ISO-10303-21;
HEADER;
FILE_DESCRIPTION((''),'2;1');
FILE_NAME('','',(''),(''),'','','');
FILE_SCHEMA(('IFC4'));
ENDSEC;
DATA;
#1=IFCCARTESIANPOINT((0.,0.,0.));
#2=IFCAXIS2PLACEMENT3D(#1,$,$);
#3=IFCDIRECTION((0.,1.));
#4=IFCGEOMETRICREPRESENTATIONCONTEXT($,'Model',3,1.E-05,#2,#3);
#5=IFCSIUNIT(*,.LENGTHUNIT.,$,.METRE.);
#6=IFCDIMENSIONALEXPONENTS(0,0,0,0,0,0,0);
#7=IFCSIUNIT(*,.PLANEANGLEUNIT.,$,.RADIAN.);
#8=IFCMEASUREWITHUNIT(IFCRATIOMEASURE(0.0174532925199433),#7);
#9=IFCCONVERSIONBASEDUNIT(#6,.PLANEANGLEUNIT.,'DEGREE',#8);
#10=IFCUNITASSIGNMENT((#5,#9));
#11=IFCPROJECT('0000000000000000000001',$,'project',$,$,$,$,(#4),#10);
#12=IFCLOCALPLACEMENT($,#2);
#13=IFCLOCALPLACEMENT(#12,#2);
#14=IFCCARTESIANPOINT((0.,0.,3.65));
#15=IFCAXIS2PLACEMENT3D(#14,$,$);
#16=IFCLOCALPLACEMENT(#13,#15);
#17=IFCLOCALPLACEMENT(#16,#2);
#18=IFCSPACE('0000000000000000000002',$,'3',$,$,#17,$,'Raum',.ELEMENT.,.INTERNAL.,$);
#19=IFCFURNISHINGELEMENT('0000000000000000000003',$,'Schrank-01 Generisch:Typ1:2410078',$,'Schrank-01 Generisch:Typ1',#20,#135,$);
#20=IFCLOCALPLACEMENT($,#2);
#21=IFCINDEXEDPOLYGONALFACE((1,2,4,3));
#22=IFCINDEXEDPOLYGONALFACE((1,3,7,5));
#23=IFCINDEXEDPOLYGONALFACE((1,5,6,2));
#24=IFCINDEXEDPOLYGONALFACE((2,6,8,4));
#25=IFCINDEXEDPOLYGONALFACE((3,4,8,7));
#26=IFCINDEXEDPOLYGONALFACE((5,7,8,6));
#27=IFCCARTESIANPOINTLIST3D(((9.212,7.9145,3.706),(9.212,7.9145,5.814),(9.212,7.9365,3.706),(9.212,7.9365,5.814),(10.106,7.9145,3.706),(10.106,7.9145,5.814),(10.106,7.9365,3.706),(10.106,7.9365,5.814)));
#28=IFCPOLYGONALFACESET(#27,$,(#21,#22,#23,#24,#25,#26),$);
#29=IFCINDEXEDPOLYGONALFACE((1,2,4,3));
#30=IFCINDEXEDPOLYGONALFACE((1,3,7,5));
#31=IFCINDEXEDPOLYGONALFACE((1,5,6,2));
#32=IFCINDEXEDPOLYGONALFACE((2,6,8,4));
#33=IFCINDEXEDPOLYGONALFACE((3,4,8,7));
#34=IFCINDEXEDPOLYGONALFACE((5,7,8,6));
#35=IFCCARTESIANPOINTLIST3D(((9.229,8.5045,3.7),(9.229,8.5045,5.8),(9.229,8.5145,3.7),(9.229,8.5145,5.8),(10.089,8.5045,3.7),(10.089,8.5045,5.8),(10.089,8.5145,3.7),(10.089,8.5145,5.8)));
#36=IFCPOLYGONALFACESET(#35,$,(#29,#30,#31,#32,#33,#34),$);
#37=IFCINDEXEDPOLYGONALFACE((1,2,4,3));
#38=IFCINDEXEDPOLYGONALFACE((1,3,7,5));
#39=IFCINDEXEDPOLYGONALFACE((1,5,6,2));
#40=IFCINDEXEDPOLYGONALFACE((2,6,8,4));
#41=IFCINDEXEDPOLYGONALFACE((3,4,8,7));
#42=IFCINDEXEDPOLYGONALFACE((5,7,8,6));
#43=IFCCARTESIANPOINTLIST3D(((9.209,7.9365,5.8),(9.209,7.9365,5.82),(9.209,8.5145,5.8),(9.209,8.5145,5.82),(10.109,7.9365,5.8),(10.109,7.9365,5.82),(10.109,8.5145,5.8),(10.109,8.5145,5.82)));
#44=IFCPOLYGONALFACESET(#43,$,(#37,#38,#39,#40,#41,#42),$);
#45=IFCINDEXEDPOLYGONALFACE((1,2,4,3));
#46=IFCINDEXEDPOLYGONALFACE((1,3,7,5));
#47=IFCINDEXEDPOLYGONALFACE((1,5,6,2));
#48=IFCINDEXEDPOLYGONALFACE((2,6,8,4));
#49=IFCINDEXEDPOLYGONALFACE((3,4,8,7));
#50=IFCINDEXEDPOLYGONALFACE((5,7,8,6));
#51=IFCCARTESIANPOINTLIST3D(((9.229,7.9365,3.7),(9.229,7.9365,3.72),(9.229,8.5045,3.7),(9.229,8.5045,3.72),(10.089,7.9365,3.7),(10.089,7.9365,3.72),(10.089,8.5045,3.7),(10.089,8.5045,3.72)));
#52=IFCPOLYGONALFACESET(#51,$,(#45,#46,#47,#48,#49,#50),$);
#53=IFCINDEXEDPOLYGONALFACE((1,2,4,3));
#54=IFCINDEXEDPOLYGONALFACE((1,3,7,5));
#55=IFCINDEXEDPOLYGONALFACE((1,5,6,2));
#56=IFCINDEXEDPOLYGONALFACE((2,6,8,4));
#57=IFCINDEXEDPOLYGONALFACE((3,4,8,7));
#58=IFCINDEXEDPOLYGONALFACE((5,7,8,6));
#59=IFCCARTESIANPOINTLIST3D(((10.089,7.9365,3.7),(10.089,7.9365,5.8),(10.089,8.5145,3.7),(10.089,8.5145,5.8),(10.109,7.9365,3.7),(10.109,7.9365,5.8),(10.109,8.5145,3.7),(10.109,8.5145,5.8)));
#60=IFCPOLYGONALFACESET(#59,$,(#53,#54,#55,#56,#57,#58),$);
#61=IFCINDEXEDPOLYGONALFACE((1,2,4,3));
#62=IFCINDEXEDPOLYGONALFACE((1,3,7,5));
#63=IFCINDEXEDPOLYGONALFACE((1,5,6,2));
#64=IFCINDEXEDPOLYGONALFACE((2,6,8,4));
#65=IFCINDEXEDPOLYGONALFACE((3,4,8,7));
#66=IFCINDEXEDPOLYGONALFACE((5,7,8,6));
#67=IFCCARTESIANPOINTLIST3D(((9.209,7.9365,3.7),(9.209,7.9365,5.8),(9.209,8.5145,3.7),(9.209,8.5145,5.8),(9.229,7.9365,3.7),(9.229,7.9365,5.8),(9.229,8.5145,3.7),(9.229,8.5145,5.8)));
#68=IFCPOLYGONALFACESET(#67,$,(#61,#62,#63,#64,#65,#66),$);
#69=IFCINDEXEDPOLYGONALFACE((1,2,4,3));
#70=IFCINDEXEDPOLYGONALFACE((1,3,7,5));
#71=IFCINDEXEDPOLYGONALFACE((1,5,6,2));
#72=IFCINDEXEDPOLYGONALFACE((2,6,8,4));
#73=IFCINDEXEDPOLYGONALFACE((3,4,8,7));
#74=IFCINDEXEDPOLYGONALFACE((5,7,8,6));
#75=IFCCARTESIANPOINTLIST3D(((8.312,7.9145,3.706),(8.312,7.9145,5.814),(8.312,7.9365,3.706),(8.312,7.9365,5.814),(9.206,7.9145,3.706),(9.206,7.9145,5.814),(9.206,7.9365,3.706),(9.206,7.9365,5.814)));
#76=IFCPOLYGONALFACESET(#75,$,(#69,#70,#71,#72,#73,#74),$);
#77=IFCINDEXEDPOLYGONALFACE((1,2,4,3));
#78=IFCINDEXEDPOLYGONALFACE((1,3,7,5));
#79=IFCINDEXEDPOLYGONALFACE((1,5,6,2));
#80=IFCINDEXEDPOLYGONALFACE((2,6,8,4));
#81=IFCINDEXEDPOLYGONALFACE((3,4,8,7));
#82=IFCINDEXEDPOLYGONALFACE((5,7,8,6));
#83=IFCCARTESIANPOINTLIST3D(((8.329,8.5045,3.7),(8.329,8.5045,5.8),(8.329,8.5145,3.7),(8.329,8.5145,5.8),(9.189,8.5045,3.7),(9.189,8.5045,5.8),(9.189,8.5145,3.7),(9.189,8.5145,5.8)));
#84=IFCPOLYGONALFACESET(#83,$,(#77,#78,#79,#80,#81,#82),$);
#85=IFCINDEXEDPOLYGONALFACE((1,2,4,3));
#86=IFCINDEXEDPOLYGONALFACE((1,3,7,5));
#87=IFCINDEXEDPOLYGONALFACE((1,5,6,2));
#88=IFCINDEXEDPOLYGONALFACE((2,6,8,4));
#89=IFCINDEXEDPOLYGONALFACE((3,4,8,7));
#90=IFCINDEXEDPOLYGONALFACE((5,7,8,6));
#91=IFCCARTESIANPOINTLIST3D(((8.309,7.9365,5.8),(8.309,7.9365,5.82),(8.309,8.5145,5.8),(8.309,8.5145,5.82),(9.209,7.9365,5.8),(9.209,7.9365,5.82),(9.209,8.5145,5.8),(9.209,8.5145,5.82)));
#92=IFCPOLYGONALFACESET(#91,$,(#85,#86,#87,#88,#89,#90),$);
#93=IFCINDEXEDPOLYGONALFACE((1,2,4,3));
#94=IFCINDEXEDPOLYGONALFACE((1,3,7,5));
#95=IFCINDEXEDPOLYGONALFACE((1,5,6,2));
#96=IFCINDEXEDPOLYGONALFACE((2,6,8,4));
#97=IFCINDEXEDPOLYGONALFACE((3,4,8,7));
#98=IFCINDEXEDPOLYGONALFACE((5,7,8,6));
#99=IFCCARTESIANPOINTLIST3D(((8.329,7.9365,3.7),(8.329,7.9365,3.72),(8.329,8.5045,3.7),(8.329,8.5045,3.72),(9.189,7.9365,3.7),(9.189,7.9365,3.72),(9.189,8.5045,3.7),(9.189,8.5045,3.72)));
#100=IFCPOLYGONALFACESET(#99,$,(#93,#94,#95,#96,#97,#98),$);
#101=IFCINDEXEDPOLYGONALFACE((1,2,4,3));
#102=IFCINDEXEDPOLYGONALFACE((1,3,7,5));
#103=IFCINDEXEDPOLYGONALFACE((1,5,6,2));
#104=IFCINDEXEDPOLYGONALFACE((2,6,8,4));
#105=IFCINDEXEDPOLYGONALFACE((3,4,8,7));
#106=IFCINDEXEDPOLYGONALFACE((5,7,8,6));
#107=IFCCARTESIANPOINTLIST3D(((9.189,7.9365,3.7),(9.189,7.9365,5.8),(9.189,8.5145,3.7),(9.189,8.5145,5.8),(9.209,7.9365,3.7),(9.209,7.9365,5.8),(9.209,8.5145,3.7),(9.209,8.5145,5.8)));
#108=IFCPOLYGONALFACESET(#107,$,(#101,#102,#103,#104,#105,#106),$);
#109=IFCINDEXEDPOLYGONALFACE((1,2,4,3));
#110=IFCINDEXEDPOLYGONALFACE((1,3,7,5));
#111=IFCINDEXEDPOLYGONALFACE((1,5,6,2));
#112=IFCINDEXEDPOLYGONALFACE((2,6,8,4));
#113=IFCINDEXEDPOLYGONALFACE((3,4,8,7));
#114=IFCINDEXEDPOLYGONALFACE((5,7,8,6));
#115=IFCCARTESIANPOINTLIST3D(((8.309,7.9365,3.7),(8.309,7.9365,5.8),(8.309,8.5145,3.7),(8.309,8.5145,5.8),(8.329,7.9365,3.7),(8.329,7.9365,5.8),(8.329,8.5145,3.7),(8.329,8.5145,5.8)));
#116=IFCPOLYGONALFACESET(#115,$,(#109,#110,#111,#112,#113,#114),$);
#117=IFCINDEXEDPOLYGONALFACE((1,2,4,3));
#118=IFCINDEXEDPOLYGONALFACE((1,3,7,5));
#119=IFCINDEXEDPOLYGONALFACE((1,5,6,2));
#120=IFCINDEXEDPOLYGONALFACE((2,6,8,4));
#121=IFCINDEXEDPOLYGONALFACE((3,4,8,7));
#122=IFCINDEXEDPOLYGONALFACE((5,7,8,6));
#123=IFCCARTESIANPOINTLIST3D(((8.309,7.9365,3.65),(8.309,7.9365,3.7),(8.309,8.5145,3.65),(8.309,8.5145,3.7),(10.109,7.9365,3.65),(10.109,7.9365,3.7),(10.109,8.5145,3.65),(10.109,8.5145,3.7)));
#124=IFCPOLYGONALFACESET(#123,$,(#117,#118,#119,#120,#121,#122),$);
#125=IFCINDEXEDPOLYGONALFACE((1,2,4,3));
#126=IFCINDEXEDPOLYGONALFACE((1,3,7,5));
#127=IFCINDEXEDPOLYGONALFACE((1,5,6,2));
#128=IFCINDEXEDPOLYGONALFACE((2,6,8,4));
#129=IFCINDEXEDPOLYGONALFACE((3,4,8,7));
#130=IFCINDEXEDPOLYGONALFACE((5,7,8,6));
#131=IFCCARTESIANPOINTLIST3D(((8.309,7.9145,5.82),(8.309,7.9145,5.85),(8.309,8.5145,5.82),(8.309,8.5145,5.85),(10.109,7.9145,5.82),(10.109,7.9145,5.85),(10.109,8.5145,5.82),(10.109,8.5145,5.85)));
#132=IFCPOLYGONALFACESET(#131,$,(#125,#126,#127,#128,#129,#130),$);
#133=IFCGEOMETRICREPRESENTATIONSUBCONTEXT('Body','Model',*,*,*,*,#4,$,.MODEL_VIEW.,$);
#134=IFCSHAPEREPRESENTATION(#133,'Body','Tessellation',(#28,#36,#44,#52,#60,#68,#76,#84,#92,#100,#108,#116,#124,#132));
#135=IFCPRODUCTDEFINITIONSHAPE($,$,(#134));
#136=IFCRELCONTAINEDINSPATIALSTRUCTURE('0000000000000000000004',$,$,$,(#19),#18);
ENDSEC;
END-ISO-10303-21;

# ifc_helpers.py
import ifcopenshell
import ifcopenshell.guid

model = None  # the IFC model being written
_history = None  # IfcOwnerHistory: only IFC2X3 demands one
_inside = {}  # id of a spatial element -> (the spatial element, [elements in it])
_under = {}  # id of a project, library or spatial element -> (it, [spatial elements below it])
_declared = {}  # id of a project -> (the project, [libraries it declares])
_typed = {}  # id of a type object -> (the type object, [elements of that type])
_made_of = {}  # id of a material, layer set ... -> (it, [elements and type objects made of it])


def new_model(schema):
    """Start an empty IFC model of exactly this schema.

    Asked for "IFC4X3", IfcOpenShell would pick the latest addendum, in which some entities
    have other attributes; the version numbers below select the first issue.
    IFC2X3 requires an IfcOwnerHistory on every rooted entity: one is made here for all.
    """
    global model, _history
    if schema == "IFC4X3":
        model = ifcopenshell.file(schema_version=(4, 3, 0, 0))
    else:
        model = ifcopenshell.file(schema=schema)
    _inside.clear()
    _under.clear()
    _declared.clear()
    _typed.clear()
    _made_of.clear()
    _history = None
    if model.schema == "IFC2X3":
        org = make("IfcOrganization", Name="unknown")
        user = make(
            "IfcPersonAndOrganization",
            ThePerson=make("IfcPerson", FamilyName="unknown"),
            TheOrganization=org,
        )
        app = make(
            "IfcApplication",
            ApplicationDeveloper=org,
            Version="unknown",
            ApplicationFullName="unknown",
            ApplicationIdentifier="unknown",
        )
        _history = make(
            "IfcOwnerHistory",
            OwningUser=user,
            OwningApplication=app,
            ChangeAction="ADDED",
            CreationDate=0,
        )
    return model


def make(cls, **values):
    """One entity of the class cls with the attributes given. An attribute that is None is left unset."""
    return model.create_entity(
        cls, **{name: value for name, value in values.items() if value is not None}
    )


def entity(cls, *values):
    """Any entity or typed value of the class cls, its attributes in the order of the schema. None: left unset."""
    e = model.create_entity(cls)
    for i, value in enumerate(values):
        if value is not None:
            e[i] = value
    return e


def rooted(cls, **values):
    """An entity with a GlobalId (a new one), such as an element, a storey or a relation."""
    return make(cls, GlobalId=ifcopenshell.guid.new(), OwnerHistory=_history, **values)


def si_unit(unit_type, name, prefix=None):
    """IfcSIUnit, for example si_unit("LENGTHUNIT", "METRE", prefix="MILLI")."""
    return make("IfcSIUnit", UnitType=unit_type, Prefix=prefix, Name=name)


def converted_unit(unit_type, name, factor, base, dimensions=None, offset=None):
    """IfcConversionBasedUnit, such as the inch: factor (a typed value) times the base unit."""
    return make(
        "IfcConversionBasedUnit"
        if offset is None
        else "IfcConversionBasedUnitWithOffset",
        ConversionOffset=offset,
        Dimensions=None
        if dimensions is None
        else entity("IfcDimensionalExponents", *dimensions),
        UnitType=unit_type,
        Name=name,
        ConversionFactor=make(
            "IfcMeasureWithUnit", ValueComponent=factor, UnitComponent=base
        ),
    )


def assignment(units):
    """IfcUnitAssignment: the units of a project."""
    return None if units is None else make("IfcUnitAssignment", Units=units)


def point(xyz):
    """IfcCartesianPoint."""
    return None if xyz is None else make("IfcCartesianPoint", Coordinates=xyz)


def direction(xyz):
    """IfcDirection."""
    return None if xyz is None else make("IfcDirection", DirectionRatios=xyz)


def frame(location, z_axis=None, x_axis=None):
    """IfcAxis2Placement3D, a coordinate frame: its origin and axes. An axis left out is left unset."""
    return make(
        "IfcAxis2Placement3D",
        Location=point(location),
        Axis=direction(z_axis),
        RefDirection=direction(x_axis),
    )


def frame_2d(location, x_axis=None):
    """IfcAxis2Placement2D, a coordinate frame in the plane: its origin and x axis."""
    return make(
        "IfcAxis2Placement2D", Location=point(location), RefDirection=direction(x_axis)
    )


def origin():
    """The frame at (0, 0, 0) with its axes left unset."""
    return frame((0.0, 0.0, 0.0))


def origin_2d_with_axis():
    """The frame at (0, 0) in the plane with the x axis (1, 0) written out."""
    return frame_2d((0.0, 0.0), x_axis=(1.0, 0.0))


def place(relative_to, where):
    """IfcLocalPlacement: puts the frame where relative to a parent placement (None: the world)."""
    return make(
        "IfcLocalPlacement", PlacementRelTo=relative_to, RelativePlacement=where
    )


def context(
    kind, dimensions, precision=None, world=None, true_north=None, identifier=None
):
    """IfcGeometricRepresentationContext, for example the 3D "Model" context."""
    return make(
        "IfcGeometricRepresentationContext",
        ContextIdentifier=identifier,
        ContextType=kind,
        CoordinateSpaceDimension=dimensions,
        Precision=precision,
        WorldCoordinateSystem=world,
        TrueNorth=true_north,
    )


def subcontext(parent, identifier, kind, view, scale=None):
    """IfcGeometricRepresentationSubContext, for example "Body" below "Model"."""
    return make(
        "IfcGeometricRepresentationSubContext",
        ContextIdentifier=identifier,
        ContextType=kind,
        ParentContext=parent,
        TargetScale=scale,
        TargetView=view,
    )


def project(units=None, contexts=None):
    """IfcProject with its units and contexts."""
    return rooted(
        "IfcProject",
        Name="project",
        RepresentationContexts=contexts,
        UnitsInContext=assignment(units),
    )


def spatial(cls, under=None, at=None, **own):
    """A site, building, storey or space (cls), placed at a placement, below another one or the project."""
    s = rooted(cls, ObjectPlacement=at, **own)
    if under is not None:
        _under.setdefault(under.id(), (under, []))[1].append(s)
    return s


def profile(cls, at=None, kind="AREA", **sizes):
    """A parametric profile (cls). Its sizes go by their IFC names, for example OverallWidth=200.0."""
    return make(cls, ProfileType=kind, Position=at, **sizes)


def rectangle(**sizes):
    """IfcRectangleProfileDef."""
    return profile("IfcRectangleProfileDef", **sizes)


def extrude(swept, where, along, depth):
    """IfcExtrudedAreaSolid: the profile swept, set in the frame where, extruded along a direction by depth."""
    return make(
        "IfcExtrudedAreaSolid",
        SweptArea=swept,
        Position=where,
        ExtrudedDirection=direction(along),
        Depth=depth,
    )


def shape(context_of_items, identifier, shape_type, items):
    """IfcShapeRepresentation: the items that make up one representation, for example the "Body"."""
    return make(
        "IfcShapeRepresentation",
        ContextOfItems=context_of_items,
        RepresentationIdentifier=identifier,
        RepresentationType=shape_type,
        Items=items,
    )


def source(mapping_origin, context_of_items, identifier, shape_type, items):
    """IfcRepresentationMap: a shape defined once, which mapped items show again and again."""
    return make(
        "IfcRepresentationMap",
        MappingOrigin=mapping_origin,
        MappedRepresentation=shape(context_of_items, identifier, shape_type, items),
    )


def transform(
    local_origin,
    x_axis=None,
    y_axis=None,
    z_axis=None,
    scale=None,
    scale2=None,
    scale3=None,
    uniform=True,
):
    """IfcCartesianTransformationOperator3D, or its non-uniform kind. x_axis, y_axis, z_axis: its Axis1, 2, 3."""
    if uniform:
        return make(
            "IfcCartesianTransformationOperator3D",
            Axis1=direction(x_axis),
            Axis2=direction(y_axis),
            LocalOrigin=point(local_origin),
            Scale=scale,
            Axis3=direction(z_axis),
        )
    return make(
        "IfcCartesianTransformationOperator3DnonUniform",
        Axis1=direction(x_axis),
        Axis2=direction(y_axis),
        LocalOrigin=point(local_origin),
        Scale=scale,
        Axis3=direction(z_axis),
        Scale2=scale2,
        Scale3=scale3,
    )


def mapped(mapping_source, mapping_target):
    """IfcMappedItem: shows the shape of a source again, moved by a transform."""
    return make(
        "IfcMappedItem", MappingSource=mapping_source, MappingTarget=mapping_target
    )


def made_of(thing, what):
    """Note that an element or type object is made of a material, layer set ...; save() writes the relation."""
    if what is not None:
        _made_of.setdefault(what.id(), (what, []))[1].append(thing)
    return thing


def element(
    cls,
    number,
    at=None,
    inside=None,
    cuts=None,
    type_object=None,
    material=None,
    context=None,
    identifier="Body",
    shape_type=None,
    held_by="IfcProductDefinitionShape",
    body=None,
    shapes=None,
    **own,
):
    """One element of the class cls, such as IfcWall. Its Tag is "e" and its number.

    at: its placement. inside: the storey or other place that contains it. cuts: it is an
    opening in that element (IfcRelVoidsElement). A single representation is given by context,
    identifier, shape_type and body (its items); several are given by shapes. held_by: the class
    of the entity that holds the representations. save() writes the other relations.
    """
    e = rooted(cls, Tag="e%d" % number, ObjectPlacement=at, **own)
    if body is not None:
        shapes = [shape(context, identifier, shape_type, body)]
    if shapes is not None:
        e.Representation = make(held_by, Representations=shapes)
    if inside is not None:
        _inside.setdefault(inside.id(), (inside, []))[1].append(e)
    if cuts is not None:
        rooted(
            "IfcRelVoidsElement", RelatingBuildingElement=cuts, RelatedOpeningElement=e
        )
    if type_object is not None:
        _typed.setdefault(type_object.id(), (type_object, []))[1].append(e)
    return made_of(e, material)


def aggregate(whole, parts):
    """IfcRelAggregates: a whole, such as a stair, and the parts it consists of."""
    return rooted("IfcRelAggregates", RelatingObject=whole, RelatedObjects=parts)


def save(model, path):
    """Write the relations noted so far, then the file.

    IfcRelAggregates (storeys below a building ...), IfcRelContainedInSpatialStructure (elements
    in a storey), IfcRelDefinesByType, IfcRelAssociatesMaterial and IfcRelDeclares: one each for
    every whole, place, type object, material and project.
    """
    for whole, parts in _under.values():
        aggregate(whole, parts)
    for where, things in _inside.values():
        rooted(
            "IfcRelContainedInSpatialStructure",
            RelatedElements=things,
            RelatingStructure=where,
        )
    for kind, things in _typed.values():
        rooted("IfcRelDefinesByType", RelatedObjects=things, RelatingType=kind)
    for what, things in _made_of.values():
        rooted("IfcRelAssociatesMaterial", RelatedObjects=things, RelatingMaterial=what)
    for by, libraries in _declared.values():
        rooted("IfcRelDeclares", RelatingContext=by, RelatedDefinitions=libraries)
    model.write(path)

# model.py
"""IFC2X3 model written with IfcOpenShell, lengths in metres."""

from ifc_helpers import new_model, entity, si_unit, converted_unit, direction, frame, frame_2d, origin, origin_2d_with_axis, place, context, subcontext, project, spatial, rectangle, extrude, source, transform, mapped, element, save


model = new_model("IFC2X3")

# Units and contexts
model_context = context("Model", 3, precision=1e-05, world=origin(), true_north=direction((0.0, 1.0)))
body_context = subcontext(model_context, "Body", "Model", "MODEL_VIEW")
ifc_project = project(units=[si_unit("LENGTHUNIT", "METRE"), converted_unit("PLANEANGLEUNIT", "DEGREE", entity("IfcRatioMeasure", 0.0174532925199433), si_unit("PLANEANGLEUNIT", "RADIAN"), dimensions=[0, 0, 0, 0, 0, 0, 0])], contexts=[model_context])

# Shared definitions
placement_1 = place(None, origin())
placement_2 = place(placement_1, origin())

# Shared definitions
placement_3 = place(placement_2, frame((0.0, 0.0, 3.65)))

# Shared definitions
space_placement = place(placement_3, origin())
space = spatial("IfcSpace", at=space_placement, Name="3", LongName="Raum", CompositionType="ELEMENT", InteriorOrExteriorSpace="INTERNAL")

# Furnishing element
shared_shape_1 = source(origin(), body_context, "Body", "SweptSolid", [
    extrude(rectangle(XDim=0.894, YDim=0.022, at=frame_2d((0.0, 0.0), x_axis=(1.0, 0.0))), frame((0.45, -0.289, 0.056), z_axis=(0.0, 0.0, 1.0), x_axis=(-1.0, 0.0, 0.0)), (0.0, 0.0, 1.0), 2.108),
    extrude(rectangle(XDim=0.86, YDim=0.01, at=origin_2d_with_axis()), frame((0.45, 0.295, 0.05), z_axis=(0.0, 0.0, 1.0), x_axis=(-1.0, 0.0, 0.0)), (0.0, 0.0, 1.0), 2.1),
    extrude(rectangle(XDim=0.9, YDim=0.578, at=origin_2d_with_axis()), frame((0.45, 0.011, 2.15), z_axis=(0.0, 0.0, 1.0), x_axis=(-1.0, 0.0, 0.0)), (0.0, 0.0, 1.0), 0.02),
    extrude(rectangle(XDim=0.86, YDim=0.568, at=origin_2d_with_axis()), frame((0.45, 0.006, 0.05), z_axis=(0.0, 0.0, 1.0), x_axis=(-1.0, 0.0, 0.0)), (0.0, 0.0, 1.0), 0.02),
    extrude(rectangle(XDim=0.02, YDim=0.578, at=origin_2d_with_axis()), frame((0.89, 0.011, 0.05), z_axis=(0.0, 0.0, 1.0), x_axis=(-1.0, 0.0, 0.0)), (0.0, 0.0, 1.0), 2.1),
    extrude(rectangle(XDim=0.02, YDim=0.578, at=origin_2d_with_axis()), frame((0.01, 0.011, 0.05), z_axis=(0.0, 0.0, 1.0), x_axis=(-1.0, 0.0, 0.0)), (0.0, 0.0, 1.0), 2.1),
    extrude(rectangle(XDim=0.894, YDim=0.022, at=frame_2d((0.0, 0.0), x_axis=(1.0, 0.0))), frame((-0.45, -0.289, 0.056), z_axis=(0.0, 0.0, 1.0), x_axis=(-1.0, 0.0, 0.0)), (0.0, 0.0, 1.0), 2.108),
    extrude(rectangle(XDim=0.86, YDim=0.01, at=frame_2d((0.0, 0.0), x_axis=(1.0, 0.0))), frame((-0.45, 0.295, 0.05), z_axis=(0.0, 0.0, 1.0), x_axis=(-1.0, 0.0, 0.0)), (0.0, 0.0, 1.0), 2.1),
    extrude(rectangle(XDim=0.9, YDim=0.578, at=frame_2d((0.0, 0.0), x_axis=(1.0, 0.0))), frame((-0.45, 0.011, 2.15), z_axis=(0.0, 0.0, 1.0), x_axis=(-1.0, 0.0, 0.0)), (0.0, 0.0, 1.0), 0.02),
    extrude(rectangle(XDim=0.86, YDim=0.568, at=frame_2d((0.0, 0.0), x_axis=(1.0, 0.0))), frame((-0.45, 0.006, 0.05), z_axis=(0.0, 0.0, 1.0), x_axis=(-1.0, 0.0, 0.0)), (0.0, 0.0, 1.0), 0.02),
    extrude(rectangle(XDim=0.02, YDim=0.578, at=origin_2d_with_axis()), frame((-0.01, 0.011, 0.05), z_axis=(0.0, 0.0, 1.0), x_axis=(-1.0, 0.0, 0.0)), (0.0, 0.0, 1.0), 2.1),
    extrude(rectangle(XDim=0.02, YDim=0.578, at=origin_2d_with_axis()), frame((-0.89, 0.011, 0.05), z_axis=(0.0, 0.0, 1.0), x_axis=(-1.0, 0.0, 0.0)), (0.0, 0.0, 1.0), 2.1),
    extrude(rectangle(XDim=1.8, YDim=0.578, at=origin_2d_with_axis()), frame((0.0, 0.011, 0.0), z_axis=(0.0, 0.0, 1.0), x_axis=(-1.0, 0.0, 0.0)), (0.0, 0.0, 1.0), 0.05),
    extrude(rectangle(XDim=1.8, YDim=0.6, at=origin_2d_with_axis()), frame((0.0, 0.0, 2.17), z_axis=(0.0, 0.0, 1.0), x_axis=(-1.0, 0.0, 0.0)), (0.0, 0.0, 1.0), 0.03),
])
furnishing_1_placement = place(space_placement, frame((9.209, 8.2145, 0.0)))
element("IfcFurnishingElement", 1, at=furnishing_1_placement, inside=space, Name="Schrank-01 Generisch:Typ1:2410078", ObjectType="Schrank-01 Generisch:Typ1", context=body_context, shape_type="MappedRepresentation", body=[
    mapped(shared_shape_1, transform((0.0, 0.0, 0.0), scale=1.0)),
])

save(model, "model.ifc")
